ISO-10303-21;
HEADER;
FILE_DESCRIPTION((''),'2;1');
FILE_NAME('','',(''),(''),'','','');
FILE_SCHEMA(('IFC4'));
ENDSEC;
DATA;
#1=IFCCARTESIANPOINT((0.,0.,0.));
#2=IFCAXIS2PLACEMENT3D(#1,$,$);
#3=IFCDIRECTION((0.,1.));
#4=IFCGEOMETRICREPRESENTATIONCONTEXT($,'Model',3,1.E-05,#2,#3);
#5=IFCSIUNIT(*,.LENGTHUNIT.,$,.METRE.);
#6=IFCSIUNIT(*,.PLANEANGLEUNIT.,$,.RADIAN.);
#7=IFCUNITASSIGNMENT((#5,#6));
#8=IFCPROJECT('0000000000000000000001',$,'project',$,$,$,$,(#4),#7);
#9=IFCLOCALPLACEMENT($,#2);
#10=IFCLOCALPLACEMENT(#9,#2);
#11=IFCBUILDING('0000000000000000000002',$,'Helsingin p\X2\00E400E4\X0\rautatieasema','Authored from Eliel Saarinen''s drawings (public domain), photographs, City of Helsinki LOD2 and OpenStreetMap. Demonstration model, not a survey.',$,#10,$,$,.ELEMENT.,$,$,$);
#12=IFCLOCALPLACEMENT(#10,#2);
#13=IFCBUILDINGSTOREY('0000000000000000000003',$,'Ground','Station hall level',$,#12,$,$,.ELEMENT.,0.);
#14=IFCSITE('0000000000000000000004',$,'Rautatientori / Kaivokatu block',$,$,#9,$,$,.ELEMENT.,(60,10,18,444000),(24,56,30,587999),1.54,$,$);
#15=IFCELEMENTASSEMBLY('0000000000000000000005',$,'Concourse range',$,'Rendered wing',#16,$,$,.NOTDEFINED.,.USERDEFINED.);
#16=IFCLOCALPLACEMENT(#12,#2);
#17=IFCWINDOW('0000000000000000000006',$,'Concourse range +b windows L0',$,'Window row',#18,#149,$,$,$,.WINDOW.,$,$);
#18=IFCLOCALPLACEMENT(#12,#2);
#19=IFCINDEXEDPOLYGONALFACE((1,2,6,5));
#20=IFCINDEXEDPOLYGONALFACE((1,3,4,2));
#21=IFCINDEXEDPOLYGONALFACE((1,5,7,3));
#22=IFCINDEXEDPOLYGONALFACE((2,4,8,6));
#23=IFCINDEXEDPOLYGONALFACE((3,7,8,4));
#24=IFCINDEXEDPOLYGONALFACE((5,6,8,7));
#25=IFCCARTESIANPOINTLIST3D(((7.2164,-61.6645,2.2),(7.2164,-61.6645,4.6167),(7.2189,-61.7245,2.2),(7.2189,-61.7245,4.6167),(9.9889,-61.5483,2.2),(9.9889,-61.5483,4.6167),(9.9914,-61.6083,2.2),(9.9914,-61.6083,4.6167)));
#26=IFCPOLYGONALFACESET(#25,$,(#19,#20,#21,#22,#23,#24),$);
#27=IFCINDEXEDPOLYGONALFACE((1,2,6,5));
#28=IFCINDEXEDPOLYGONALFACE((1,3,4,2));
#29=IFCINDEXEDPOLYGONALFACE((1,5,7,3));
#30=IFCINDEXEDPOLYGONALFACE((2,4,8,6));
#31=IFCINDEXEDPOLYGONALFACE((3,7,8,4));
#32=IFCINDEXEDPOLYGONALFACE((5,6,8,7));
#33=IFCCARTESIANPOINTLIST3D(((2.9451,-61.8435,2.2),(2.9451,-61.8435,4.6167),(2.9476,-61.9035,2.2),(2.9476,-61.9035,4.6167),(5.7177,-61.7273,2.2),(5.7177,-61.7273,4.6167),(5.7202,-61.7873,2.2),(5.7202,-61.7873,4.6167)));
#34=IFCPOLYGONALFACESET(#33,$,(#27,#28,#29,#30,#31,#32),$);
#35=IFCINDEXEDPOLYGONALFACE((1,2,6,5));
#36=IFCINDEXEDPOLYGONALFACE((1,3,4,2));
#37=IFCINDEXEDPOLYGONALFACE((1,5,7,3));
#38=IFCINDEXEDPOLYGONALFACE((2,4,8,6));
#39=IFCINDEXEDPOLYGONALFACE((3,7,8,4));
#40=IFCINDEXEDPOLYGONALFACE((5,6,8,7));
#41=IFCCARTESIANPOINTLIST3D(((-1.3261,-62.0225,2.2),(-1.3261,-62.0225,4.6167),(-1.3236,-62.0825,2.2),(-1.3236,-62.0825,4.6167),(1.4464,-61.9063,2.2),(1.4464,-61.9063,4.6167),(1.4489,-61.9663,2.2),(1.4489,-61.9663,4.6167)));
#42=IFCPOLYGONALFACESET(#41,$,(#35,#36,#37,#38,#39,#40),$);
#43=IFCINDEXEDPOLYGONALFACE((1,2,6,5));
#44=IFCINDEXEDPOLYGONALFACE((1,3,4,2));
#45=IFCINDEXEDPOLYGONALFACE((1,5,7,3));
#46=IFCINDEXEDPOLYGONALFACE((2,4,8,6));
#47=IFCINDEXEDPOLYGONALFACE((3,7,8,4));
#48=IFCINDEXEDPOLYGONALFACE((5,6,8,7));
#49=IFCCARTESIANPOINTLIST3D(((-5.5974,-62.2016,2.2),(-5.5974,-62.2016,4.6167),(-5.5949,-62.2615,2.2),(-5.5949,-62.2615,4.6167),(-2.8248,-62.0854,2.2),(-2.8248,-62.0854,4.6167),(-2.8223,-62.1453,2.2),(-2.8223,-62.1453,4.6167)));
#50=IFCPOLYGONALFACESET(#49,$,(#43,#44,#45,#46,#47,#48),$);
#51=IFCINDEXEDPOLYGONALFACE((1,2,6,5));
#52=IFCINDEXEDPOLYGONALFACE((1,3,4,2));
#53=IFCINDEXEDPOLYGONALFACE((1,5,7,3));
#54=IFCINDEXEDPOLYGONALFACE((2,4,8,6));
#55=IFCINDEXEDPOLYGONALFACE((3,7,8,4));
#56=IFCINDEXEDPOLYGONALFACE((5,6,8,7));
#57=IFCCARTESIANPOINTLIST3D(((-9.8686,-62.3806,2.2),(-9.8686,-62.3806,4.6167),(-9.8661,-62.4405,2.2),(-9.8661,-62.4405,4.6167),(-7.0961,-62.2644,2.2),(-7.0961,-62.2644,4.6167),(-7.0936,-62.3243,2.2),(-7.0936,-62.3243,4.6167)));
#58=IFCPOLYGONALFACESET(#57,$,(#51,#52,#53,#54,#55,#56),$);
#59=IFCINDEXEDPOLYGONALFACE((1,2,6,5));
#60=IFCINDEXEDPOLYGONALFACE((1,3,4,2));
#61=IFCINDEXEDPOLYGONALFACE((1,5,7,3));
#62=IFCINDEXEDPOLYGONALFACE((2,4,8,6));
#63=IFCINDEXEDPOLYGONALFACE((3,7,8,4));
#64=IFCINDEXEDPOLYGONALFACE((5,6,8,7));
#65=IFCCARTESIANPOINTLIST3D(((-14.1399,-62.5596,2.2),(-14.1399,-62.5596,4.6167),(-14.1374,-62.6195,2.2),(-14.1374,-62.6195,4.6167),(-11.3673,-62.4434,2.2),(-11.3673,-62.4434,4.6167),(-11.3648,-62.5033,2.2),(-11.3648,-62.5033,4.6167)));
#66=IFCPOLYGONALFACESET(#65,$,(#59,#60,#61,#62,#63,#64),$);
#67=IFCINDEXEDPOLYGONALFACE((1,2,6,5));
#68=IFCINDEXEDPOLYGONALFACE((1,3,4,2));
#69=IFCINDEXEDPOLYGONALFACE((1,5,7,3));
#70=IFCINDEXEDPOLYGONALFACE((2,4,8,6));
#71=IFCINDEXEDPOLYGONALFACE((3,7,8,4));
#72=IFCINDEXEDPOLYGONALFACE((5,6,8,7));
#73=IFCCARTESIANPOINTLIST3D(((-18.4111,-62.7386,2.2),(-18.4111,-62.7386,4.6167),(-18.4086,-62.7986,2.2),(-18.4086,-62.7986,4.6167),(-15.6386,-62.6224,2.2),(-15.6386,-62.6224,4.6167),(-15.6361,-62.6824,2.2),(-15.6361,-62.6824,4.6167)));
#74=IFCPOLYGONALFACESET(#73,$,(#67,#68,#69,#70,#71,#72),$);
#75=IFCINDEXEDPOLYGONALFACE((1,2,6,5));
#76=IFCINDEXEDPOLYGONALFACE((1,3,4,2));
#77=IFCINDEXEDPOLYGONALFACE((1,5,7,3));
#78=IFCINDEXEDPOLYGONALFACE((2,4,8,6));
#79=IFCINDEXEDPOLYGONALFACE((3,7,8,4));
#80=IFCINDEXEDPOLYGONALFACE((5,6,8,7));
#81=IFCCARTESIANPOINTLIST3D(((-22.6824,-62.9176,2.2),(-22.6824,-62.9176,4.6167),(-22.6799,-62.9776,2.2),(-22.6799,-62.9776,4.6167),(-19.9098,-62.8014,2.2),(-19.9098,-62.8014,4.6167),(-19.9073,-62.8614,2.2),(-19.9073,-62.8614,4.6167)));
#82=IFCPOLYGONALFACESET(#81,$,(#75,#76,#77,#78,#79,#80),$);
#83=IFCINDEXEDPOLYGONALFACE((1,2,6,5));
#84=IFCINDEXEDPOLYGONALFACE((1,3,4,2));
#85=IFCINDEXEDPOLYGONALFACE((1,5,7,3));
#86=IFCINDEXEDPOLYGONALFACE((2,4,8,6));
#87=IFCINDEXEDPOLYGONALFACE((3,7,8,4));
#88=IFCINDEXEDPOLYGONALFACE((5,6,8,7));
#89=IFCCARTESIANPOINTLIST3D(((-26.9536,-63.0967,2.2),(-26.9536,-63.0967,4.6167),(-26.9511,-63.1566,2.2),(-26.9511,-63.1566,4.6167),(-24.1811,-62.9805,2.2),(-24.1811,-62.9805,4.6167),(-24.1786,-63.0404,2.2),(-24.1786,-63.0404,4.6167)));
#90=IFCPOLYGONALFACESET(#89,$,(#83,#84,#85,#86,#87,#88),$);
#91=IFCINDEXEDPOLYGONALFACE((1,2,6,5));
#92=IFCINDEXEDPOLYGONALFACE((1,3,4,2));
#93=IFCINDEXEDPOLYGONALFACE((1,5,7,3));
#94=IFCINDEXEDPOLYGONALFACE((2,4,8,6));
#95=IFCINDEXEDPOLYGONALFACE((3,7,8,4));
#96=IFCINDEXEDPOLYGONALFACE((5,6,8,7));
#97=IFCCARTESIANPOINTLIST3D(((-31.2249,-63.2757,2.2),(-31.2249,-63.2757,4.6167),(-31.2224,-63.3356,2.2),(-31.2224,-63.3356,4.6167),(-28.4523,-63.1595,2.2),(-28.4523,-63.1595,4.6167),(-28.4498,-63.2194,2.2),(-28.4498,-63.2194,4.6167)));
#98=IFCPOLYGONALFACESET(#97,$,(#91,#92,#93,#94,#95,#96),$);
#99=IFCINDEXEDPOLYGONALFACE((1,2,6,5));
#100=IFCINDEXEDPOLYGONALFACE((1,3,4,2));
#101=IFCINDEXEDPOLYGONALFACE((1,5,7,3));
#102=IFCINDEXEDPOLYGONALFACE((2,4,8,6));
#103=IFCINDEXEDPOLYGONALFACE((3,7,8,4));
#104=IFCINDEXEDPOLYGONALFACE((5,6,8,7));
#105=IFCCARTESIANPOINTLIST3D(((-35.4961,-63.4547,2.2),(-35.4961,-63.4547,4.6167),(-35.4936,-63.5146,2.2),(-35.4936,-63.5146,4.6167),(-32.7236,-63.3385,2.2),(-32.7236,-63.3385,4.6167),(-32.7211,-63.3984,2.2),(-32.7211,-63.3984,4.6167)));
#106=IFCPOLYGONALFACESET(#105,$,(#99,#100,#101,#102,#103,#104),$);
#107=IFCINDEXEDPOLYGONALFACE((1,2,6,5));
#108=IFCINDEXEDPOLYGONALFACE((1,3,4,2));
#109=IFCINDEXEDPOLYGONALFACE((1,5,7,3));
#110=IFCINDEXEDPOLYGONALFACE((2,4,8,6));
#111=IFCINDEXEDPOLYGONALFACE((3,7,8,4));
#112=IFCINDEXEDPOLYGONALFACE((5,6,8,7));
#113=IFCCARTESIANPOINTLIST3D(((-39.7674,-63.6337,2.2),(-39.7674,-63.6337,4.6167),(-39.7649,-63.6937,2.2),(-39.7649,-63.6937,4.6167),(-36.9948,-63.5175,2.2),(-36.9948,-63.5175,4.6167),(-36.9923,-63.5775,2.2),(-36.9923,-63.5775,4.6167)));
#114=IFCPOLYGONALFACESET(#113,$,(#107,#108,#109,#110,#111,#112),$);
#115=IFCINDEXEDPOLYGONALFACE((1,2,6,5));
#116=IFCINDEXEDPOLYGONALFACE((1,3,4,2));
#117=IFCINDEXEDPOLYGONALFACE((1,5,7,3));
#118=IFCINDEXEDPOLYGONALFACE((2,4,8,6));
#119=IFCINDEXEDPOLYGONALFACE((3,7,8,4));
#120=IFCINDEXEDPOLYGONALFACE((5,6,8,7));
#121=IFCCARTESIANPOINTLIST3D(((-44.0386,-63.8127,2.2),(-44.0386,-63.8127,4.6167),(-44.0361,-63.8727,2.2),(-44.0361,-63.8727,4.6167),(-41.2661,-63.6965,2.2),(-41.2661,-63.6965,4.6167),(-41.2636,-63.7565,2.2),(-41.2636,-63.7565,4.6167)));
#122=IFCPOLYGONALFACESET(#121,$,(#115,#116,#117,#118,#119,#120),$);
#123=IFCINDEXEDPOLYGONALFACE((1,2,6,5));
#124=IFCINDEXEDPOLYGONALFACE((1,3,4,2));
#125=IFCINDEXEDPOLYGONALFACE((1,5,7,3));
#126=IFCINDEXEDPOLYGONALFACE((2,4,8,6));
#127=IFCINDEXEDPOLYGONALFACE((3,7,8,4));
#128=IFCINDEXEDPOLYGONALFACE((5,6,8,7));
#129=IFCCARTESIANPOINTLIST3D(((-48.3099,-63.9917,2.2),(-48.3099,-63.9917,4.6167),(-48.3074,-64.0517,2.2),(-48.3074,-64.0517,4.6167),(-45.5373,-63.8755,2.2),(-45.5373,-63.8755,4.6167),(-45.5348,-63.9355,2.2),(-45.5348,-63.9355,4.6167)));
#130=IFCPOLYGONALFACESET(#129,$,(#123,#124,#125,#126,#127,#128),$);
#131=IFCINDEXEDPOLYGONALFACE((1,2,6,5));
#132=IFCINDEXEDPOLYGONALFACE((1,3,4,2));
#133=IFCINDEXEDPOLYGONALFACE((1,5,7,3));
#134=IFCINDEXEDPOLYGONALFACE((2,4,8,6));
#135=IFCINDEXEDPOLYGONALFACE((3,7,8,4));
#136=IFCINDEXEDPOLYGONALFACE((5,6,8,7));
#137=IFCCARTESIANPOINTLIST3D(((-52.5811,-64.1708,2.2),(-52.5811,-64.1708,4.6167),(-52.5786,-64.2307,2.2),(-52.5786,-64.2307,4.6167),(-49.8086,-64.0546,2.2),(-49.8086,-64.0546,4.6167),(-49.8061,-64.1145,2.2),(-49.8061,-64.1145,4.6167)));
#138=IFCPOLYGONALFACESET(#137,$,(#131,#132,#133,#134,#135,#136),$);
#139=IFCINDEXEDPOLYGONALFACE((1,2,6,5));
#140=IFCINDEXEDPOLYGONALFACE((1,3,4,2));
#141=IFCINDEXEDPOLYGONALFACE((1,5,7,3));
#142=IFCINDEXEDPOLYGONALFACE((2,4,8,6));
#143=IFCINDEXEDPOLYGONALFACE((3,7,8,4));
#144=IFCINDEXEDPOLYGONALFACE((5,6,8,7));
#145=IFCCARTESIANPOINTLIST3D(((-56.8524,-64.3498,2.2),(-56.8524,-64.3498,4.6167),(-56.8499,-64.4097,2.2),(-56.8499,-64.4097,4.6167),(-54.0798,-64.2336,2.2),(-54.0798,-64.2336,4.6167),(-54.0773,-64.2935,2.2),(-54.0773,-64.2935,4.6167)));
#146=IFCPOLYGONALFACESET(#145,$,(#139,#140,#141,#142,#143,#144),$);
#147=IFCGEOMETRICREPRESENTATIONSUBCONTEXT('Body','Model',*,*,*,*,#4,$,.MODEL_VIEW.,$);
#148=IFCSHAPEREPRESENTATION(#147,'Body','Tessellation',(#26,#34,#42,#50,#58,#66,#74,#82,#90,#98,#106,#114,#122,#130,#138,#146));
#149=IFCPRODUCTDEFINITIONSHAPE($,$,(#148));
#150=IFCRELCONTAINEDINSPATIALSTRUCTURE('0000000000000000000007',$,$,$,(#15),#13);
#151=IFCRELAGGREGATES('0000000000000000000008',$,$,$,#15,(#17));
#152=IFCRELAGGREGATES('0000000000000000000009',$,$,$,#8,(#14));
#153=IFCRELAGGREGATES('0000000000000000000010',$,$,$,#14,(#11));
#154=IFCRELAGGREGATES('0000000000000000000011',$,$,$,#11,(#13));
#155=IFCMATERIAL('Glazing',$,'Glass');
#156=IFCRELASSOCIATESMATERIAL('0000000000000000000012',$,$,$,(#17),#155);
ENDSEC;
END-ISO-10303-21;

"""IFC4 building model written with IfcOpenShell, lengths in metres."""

from ifc_helpers import new_model, si_unit, direction, frame, frame_2d, origin, place, context, subcontext, project, spatial, rectangle, extrude, material, element, aggregate, save


model = new_model("IFC4")

# Units and contexts
model_context = context("Model", 3, precision=1e-05, world=origin(), true_north=direction((0.0, 1.0)))
body_context = subcontext(model_context, "Body", "Model", "MODEL_VIEW")
ifc_project = project(units=[si_unit("LENGTHUNIT", "METRE"), si_unit("PLANEANGLEUNIT", "RADIAN")], contexts=[model_context])

# Site, building, storey
site_placement = place(None, origin())
site = spatial("IfcSite", under=ifc_project, at=site_placement, Name="Rautatientori / Kaivokatu block", CompositionType="ELEMENT", RefLatitude=(60, 10, 18, 444000), RefLongitude=(24, 56, 30, 587999), RefElevation=1.54)
building_placement = place(site_placement, origin())
building = spatial("IfcBuilding", under=site, at=building_placement, Name="Helsingin päärautatieasema", Description="Authored from Eliel Saarinen's drawings (public domain), photographs, City of Helsinki LOD2 and OpenStreetMap. Demonstration model, not a survey.", CompositionType="ELEMENT")
storey_placement = place(building_placement, origin())
storey = spatial("IfcBuildingStorey", under=building, at=storey_placement, Name="Ground", Description="Station hall level", CompositionType="ELEMENT", Elevation=0.0)

# Element assembly
assembly_1_placement = place(building_placement, origin())
assembly_1 = element("IfcElementAssembly", 1, at=assembly_1_placement, inside=storey, Name="Concourse range", ObjectType="Rendered wing", AssemblyPlace="NOTDEFINED", PredefinedType="USERDEFINED")

# Window
ifc_material_1 = material(Name="Glazing", Category="Glass")
window_1_placement = place(building_placement, origin())
window_1 = element("IfcWindow", 2, at=window_1_placement, material=ifc_material_1, Name="Concourse range +b windows L0", ObjectType="Window row", PredefinedType="WINDOW", context=body_context, shape_type="SweptSolid", body=[
    extrude(rectangle(XDim=2.775, YDim=0.06, at=frame_2d((0.0, 0.0), x_axis=(-0.999123, -0.041876))), frame((8.6039, -61.6364, 2.2)), (0.0, 0.0, 1.0), 2.4167),
    extrude(rectangle(XDim=2.775, YDim=0.06, at=frame_2d((0.0, 0.0), x_axis=(-0.999123, -0.041876))), frame((4.3326, -61.8154, 2.2)), (0.0, 0.0, 1.0), 2.4167),
    extrude(rectangle(XDim=2.775, YDim=0.06, at=frame_2d((0.0, 0.0), x_axis=(-0.999123, -0.041876))), frame((0.0614, -61.9944, 2.2)), (0.0, 0.0, 1.0), 2.4167),
    extrude(rectangle(XDim=2.775, YDim=0.06, at=frame_2d((0.0, 0.0), x_axis=(-0.999123, -0.041876))), frame((-4.2099, -62.1734, 2.2)), (0.0, 0.0, 1.0), 2.4167),
    extrude(rectangle(XDim=2.775, YDim=0.06, at=frame_2d((0.0, 0.0), x_axis=(-0.999123, -0.041876))), frame((-8.4811, -62.3525, 2.2)), (0.0, 0.0, 1.0), 2.4167),
    extrude(rectangle(XDim=2.775, YDim=0.06, at=frame_2d((0.0, 0.0), x_axis=(-0.999123, -0.041876))), frame((-12.7524, -62.5315, 2.2)), (0.0, 0.0, 1.0), 2.4167),
    extrude(rectangle(XDim=2.775, YDim=0.06, at=frame_2d((0.0, 0.0), x_axis=(-0.999123, -0.041876))), frame((-17.0236, -62.7105, 2.2)), (0.0, 0.0, 1.0), 2.4167),
    extrude(rectangle(XDim=2.775, YDim=0.06, at=frame_2d((0.0, 0.0), x_axis=(-0.999123, -0.041876))), frame((-21.2949, -62.8895, 2.2)), (0.0, 0.0, 1.0), 2.4167),
    extrude(rectangle(XDim=2.775, YDim=0.06, at=frame_2d((0.0, 0.0), x_axis=(-0.999123, -0.041876))), frame((-25.5661, -63.0685, 2.2)), (0.0, 0.0, 1.0), 2.4167),
    extrude(rectangle(XDim=2.775, YDim=0.06, at=frame_2d((0.0, 0.0), x_axis=(-0.999123, -0.041876))), frame((-29.8374, -63.2475, 2.2)), (0.0, 0.0, 1.0), 2.4167),
    extrude(rectangle(XDim=2.775, YDim=0.06, at=frame_2d((0.0, 0.0), x_axis=(-0.999123, -0.041876))), frame((-34.1086, -63.4266, 2.2)), (0.0, 0.0, 1.0), 2.4167),
    extrude(rectangle(XDim=2.775, YDim=0.06, at=frame_2d((0.0, 0.0), x_axis=(-0.999123, -0.041876))), frame((-38.3799, -63.6056, 2.2)), (0.0, 0.0, 1.0), 2.4167),
    extrude(rectangle(XDim=2.775, YDim=0.06, at=frame_2d((0.0, 0.0), x_axis=(-0.999123, -0.041876))), frame((-42.6511, -63.7846, 2.2)), (0.0, 0.0, 1.0), 2.4167),
    extrude(rectangle(XDim=2.775, YDim=0.06, at=frame_2d((0.0, 0.0), x_axis=(-0.999123, -0.041876))), frame((-46.9224, -63.9636, 2.2)), (0.0, 0.0, 1.0), 2.4167),
    extrude(rectangle(XDim=2.775, YDim=0.06, at=frame_2d((0.0, 0.0), x_axis=(-0.999123, -0.041876))), frame((-51.1936, -64.1426, 2.2)), (0.0, 0.0, 1.0), 2.4167),
    extrude(rectangle(XDim=2.775, YDim=0.06, at=frame_2d((0.0, 0.0), x_axis=(-0.999123, -0.041876))), frame((-55.4649, -64.3217, 2.2)), (0.0, 0.0, 1.0), 2.4167),
])

aggregate(assembly_1, [window_1])

save(model, "model.ifc")
